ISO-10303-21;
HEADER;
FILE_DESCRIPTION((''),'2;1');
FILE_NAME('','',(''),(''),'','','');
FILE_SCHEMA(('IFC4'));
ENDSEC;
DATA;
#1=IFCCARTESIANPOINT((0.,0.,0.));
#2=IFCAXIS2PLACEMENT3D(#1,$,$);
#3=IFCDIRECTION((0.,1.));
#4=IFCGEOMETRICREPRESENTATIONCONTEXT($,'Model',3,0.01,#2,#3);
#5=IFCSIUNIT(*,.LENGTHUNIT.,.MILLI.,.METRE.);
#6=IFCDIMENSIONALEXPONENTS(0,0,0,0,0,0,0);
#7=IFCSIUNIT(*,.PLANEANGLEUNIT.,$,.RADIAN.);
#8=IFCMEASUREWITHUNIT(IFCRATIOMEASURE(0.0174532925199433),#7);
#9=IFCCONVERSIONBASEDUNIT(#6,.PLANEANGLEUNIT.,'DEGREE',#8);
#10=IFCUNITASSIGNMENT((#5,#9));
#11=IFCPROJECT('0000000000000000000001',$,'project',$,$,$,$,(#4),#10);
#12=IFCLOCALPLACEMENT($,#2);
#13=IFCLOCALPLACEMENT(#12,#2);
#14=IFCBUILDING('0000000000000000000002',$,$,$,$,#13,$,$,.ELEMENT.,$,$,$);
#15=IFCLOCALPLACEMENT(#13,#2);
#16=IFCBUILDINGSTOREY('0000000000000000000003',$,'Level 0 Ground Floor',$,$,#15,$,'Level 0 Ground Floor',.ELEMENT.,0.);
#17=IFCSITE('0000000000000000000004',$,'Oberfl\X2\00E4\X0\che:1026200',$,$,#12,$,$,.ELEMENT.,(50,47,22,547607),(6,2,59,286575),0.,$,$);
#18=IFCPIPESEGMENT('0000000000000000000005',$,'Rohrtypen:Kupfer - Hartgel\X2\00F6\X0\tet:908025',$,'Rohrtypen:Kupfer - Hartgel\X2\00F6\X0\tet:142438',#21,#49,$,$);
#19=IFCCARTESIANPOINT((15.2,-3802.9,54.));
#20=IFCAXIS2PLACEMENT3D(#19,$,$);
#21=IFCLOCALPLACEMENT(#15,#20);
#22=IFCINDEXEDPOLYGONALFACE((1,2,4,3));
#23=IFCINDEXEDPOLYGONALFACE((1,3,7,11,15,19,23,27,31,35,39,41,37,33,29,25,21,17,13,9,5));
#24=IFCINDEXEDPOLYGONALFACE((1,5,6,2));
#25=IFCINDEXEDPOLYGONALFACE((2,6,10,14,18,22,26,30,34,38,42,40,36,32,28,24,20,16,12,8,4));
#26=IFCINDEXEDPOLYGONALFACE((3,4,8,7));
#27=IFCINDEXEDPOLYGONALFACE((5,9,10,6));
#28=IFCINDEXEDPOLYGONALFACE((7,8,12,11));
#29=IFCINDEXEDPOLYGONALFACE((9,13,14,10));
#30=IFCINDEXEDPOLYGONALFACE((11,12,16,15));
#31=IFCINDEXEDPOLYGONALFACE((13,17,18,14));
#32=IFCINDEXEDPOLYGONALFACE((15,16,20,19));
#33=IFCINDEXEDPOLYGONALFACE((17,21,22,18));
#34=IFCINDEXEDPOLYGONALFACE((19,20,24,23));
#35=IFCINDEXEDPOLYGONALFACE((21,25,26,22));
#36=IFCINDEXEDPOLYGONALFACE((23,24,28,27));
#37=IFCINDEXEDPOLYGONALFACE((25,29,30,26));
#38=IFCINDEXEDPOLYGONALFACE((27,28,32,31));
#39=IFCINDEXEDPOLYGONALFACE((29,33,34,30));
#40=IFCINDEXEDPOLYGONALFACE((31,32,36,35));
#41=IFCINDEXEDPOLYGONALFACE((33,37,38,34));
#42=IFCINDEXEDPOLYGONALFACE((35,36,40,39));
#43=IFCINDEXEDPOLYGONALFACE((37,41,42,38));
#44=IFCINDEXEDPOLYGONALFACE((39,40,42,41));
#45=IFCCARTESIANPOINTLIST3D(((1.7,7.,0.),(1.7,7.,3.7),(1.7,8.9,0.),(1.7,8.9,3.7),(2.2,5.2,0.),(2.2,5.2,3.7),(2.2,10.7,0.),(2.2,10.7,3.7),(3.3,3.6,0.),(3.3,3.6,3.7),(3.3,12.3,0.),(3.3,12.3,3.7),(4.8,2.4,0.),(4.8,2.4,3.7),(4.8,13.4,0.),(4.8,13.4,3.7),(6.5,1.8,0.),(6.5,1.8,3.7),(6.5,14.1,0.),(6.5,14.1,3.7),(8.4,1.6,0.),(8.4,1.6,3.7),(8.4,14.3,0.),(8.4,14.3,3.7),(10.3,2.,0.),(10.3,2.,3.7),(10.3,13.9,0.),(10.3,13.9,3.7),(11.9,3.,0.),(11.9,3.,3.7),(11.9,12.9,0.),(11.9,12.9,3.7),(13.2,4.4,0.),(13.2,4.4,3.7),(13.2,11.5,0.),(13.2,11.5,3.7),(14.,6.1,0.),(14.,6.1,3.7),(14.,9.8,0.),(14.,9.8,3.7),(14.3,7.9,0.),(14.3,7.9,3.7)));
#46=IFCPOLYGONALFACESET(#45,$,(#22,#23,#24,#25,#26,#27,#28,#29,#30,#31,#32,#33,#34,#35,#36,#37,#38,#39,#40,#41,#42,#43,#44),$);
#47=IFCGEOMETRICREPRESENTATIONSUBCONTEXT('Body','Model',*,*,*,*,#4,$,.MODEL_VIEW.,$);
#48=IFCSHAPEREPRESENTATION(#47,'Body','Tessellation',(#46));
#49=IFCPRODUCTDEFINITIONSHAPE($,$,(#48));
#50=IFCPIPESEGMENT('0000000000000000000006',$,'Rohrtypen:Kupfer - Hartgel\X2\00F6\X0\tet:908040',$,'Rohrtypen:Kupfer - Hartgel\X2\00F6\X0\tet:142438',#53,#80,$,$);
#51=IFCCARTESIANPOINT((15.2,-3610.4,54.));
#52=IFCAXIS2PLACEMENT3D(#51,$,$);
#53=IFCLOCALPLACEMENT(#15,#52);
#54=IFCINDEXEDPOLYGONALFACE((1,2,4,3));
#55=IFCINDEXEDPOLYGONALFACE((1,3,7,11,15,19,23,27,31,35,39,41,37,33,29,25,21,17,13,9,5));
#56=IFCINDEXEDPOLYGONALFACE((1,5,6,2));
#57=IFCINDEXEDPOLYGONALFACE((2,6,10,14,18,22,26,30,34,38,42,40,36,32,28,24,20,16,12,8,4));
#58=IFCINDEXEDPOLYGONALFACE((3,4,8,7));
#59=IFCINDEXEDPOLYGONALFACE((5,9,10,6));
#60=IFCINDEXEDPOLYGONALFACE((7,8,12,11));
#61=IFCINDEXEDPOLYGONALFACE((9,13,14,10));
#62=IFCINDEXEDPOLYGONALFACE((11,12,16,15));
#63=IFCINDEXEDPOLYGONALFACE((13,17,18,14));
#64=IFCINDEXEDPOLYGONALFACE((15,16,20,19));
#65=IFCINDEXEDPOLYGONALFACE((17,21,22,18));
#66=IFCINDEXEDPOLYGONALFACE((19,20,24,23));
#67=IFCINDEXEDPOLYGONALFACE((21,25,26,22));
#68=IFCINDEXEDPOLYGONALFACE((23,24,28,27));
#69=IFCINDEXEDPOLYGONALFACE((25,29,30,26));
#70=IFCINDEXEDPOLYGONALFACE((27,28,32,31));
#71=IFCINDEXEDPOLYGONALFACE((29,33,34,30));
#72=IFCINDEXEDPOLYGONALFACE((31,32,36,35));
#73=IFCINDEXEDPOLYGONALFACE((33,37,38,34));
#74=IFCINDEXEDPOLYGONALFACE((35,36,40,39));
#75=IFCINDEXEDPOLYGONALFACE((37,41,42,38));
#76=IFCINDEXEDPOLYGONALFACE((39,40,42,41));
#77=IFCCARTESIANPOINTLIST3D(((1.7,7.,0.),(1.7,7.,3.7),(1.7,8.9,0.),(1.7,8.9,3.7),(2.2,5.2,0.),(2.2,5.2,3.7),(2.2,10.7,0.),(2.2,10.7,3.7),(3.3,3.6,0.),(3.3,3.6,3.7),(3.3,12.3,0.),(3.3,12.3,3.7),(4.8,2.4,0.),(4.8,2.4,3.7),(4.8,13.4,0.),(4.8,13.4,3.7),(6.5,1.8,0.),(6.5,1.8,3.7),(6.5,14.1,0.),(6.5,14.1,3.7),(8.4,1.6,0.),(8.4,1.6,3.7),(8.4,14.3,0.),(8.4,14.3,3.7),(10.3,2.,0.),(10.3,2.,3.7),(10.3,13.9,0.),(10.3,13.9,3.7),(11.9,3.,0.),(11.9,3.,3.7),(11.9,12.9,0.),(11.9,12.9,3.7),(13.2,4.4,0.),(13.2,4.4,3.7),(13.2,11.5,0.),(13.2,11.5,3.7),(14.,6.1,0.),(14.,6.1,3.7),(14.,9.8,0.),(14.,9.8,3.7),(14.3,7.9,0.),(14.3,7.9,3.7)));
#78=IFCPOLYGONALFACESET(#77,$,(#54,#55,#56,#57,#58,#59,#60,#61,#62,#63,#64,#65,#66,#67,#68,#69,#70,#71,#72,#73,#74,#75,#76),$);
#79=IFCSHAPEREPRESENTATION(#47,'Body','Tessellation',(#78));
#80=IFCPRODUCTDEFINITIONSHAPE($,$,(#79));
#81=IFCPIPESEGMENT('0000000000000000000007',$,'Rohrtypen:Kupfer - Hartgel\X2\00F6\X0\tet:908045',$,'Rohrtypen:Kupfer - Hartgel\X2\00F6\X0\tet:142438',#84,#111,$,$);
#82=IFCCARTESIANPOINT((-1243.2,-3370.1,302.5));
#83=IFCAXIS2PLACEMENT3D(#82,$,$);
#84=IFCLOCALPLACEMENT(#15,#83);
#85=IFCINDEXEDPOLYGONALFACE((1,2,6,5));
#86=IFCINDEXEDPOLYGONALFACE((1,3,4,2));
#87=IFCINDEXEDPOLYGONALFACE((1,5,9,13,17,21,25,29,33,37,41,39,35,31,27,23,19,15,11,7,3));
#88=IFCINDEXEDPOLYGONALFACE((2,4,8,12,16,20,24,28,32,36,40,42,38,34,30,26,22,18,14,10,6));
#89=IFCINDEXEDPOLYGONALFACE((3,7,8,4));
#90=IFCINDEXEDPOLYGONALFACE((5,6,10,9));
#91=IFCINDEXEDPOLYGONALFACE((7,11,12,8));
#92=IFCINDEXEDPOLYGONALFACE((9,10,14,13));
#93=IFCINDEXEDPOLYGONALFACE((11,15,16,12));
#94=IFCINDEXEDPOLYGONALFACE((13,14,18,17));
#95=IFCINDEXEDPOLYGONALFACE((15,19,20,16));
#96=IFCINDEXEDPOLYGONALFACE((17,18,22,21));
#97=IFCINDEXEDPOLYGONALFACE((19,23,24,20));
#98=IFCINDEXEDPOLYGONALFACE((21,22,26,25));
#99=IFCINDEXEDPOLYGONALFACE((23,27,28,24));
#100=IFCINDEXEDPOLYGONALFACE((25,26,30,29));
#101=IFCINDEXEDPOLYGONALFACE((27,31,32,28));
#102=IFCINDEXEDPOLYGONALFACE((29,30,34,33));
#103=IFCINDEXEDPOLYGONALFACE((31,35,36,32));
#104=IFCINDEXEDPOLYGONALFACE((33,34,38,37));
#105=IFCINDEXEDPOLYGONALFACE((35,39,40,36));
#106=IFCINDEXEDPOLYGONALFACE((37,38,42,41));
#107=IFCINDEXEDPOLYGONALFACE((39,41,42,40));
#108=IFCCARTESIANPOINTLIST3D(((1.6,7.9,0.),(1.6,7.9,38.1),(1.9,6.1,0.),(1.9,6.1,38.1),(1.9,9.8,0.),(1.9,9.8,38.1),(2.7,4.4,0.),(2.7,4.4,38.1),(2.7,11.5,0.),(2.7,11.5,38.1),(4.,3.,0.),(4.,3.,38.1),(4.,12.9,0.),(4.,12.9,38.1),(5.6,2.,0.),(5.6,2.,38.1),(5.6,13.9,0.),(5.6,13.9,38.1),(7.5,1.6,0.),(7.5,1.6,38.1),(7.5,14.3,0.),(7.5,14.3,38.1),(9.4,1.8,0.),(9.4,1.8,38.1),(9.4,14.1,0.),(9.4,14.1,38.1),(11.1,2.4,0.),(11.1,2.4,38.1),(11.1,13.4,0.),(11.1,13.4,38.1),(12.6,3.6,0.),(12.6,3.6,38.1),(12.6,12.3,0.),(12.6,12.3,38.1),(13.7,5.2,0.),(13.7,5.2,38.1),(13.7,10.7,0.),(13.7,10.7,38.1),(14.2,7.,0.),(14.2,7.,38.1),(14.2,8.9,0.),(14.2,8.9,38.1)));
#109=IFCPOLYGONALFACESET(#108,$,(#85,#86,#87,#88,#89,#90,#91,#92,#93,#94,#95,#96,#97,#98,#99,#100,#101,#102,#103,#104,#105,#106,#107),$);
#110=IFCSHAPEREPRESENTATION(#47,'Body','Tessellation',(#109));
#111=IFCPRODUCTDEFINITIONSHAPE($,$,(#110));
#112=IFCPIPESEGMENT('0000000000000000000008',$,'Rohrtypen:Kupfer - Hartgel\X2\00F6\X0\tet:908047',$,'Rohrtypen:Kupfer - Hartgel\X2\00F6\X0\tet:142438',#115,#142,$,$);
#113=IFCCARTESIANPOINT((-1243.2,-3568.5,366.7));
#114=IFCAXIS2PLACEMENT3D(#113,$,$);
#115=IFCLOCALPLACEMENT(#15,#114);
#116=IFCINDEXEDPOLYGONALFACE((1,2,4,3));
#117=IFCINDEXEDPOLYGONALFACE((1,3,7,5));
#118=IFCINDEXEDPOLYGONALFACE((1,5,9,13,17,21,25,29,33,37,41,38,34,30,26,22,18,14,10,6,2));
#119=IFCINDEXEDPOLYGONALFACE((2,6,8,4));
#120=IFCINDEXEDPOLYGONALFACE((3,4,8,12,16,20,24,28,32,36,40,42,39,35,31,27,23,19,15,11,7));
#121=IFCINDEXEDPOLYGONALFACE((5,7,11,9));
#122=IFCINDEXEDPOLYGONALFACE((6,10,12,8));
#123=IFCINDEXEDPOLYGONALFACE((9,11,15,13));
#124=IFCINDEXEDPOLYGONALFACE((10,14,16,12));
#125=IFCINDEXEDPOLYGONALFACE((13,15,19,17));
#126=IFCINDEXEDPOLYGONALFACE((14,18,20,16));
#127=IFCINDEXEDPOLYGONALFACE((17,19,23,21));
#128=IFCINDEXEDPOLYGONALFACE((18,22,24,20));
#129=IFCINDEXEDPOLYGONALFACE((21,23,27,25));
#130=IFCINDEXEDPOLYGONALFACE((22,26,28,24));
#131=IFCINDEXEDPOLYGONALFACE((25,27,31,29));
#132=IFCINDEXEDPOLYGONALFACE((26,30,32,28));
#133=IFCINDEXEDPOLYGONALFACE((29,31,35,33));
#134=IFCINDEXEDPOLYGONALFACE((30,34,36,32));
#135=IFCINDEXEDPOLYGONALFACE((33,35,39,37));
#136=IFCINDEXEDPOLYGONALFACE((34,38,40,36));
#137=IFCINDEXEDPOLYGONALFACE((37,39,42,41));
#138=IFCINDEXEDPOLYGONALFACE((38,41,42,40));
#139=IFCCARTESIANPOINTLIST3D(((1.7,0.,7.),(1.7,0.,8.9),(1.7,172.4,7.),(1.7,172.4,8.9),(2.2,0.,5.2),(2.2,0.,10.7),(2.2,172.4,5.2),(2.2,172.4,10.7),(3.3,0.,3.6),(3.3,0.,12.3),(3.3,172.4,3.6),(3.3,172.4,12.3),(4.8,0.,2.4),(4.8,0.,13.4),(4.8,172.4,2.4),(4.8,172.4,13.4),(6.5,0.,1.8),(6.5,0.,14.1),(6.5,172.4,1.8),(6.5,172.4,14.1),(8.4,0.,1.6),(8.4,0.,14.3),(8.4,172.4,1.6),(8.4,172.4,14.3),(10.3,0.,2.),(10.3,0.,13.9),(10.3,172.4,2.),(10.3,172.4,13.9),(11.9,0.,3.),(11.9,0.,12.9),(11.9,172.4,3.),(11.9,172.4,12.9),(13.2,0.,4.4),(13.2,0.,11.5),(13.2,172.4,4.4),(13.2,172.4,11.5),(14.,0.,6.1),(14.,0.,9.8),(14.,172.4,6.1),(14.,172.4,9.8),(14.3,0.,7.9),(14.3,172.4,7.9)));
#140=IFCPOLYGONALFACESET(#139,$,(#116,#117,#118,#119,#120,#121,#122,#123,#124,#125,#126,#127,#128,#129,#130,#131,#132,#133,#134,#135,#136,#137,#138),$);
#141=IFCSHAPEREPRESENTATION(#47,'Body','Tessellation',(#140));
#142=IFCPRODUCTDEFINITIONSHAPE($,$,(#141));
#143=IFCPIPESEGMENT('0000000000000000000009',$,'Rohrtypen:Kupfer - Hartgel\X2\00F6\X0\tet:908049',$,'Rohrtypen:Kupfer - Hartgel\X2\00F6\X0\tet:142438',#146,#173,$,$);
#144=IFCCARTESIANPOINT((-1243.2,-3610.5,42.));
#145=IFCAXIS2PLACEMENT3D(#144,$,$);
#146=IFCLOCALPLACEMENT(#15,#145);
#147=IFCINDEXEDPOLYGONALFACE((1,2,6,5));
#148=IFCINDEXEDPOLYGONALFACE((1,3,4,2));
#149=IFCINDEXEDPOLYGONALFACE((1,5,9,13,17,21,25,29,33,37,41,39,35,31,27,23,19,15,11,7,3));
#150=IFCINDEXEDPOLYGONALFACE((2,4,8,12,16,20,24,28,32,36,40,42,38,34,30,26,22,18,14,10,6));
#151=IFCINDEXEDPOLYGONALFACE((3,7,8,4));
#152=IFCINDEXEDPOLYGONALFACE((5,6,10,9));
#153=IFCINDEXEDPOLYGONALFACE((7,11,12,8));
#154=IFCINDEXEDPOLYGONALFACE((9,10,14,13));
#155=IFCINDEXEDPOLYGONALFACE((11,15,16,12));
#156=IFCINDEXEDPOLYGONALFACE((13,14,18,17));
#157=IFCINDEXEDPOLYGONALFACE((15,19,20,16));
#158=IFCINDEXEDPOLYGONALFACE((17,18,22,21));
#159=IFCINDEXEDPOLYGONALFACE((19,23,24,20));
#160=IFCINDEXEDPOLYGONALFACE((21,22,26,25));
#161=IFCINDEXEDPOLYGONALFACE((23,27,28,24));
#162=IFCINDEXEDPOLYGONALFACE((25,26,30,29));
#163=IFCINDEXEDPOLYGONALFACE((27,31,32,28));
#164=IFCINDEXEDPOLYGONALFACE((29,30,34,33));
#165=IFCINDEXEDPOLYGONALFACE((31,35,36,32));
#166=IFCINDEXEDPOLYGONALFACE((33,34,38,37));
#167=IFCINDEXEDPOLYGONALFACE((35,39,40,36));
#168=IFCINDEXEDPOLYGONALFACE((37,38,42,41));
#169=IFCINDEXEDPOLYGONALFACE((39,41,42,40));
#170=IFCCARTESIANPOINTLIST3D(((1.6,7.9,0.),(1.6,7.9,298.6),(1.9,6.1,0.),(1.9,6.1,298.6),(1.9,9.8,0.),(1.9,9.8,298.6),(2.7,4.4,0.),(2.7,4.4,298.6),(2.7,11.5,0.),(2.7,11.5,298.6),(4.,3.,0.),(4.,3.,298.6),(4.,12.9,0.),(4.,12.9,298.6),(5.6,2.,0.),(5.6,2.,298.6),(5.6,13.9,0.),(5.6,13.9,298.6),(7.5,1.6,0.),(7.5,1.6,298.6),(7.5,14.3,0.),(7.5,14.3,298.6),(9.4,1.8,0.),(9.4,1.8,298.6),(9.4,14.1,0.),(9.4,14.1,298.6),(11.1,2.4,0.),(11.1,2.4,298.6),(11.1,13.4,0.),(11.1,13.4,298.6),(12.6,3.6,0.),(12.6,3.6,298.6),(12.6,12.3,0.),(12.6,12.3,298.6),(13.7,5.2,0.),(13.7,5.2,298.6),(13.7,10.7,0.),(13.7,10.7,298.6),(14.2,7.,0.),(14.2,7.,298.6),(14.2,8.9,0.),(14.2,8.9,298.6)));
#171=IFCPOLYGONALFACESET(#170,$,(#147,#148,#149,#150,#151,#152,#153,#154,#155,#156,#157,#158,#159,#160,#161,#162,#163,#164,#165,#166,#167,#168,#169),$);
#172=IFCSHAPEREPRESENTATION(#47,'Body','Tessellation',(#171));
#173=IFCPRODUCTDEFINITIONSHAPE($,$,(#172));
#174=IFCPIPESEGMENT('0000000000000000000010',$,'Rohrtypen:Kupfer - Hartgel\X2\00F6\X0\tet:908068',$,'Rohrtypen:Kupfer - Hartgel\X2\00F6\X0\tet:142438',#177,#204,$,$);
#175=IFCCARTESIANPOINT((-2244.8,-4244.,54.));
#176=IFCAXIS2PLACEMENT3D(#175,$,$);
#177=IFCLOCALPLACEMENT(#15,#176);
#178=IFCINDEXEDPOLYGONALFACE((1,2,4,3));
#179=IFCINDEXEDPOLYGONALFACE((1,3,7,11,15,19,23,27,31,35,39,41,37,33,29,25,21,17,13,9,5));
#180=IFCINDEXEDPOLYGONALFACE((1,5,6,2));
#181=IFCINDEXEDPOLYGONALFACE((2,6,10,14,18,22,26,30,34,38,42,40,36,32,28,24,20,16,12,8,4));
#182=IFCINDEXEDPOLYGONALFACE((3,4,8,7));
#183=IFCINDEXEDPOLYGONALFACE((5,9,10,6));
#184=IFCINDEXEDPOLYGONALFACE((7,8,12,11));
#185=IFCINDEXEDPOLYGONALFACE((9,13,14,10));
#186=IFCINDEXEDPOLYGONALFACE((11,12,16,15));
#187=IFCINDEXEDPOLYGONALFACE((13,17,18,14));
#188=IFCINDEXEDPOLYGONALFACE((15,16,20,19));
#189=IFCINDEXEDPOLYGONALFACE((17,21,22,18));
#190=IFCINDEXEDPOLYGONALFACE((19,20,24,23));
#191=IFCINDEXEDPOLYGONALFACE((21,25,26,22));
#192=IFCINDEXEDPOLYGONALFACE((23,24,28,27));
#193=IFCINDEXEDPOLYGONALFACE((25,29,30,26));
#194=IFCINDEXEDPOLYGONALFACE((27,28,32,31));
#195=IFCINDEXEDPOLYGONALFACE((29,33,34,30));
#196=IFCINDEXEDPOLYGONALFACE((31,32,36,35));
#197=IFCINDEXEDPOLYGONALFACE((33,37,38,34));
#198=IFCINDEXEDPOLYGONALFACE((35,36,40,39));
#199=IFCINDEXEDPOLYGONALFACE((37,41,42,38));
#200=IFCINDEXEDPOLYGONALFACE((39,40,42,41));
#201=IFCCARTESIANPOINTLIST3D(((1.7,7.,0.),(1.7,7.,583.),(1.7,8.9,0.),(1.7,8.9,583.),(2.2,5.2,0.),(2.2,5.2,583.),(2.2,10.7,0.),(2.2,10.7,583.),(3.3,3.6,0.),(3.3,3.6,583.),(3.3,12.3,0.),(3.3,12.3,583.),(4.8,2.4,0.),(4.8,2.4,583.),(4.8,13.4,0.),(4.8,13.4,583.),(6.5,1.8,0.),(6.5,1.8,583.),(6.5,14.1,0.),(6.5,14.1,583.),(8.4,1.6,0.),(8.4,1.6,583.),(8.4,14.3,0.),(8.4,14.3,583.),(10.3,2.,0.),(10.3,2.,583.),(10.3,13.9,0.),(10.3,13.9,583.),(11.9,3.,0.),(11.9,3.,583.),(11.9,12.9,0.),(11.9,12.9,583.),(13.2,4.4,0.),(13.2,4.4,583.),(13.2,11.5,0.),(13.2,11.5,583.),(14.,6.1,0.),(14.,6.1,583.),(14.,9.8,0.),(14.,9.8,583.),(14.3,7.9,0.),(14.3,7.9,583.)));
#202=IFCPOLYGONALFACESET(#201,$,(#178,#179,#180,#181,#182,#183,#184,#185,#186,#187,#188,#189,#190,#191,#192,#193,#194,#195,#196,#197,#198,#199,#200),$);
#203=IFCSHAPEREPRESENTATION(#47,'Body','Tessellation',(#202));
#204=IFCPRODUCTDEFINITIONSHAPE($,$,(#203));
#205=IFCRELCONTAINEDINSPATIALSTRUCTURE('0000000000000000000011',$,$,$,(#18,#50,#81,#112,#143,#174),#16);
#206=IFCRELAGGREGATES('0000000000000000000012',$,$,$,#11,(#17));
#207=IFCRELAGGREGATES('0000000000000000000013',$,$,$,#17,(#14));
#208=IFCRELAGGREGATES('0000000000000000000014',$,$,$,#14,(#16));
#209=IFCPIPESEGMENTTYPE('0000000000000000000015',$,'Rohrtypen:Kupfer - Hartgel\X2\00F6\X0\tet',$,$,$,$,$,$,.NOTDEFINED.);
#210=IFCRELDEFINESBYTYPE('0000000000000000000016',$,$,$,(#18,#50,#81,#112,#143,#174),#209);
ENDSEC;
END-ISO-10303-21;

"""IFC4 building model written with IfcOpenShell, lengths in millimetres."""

from ifc_helpers import new_model, entity, si_unit, converted_unit, direction, frame, frame_2d, origin, origin_2d_with_axis, place, context, subcontext, project, spatial, circle, extrude, type_object, element, save


model = new_model("IFC4")

# Units and contexts
model_context = context("Model", 3, precision=0.01, world=origin(), true_north=direction((0.0, 1.0)))
body_context = subcontext(model_context, "Body", "Model", "MODEL_VIEW")
ifc_project = project(units=[si_unit("LENGTHUNIT", "METRE", prefix="MILLI"), converted_unit("PLANEANGLEUNIT", "DEGREE", entity("IfcRatioMeasure", 0.0174532925199433), si_unit("PLANEANGLEUNIT", "RADIAN"), dimensions=[0, 0, 0, 0, 0, 0, 0])], contexts=[model_context])

# Site, building, storey
site_placement = place(None, origin())
site = spatial("IfcSite", under=ifc_project, at=site_placement, Name="Oberfläche:1026200", CompositionType="ELEMENT", RefLatitude=(50, 47, 22, 547607), RefLongitude=(6, 2, 59, 286575), RefElevation=0.0)
building_placement = place(site_placement, origin())
building = spatial("IfcBuilding", under=site, at=building_placement, CompositionType="ELEMENT")
storey_placement = place(building_placement, origin())
storey = spatial("IfcBuildingStorey", under=building, at=storey_placement, Name="Level 0 Ground Floor", LongName="Level 0 Ground Floor", CompositionType="ELEMENT", Elevation=0.0)

# Pipe segments
pipe_segment_type = type_object("IfcPipeSegmentType", Name="Rohrtypen:Kupfer - Hartgelötet", PredefinedType="NOTDEFINED")
pipe_segment_1_placement = place(storey_placement, frame((15.2, -3802.9, 54.0)))
element("IfcPipeSegment", 1, at=pipe_segment_1_placement, inside=storey, type_object=pipe_segment_type, Name="Rohrtypen:Kupfer - Hartgelötet:908025", ObjectType="Rohrtypen:Kupfer - Hartgelötet:142438", context=body_context, shape_type="SweptSolid", body=[
    extrude(circle(Radius=6.3, at=frame_2d((0.0, 0.0), x_axis=(1.0, 0.0))), frame((7.9, 7.9, 0.0)), (0.0, 0.0, 1.0), 3.7),
])
pipe_segment_2_placement = place(storey_placement, frame((15.2, -3610.4, 54.0)))
element("IfcPipeSegment", 2, at=pipe_segment_2_placement, inside=storey, type_object=pipe_segment_type, Name="Rohrtypen:Kupfer - Hartgelötet:908040", ObjectType="Rohrtypen:Kupfer - Hartgelötet:142438", context=body_context, shape_type="SweptSolid", body=[
    extrude(circle(Radius=6.3, at=frame_2d((0.0, 0.0), x_axis=(1.0, 0.0))), frame((7.9, 7.9, 0.0)), (0.0, 0.0, 1.0), 3.7),
])
pipe_segment_3_placement = place(storey_placement, frame((-1243.2, -3370.1, 302.5)))
element("IfcPipeSegment", 3, at=pipe_segment_3_placement, inside=storey, type_object=pipe_segment_type, Name="Rohrtypen:Kupfer - Hartgelötet:908045", ObjectType="Rohrtypen:Kupfer - Hartgelötet:142438", context=body_context, shape_type="SweptSolid", body=[
    extrude(circle(Radius=6.3, at=origin_2d_with_axis()), frame((7.9, 7.9, 0.0), z_axis=(0.0, 0.0, 1.0), x_axis=(-1.0, 0.0, 0.0)), (0.0, 0.0, 1.0), 38.1),
])
pipe_segment_4_placement = place(storey_placement, frame((-1243.2, -3568.5, 366.7)))
element("IfcPipeSegment", 4, at=pipe_segment_4_placement, inside=storey, type_object=pipe_segment_type, Name="Rohrtypen:Kupfer - Hartgelötet:908047", ObjectType="Rohrtypen:Kupfer - Hartgelötet:142438", context=body_context, shape_type="SweptSolid", body=[
    extrude(circle(Radius=6.3, at=frame_2d((0.0, 0.0), x_axis=(1.0, 0.0))), frame((7.9, 0.0, 7.9), z_axis=(0.0, 1.0, 0.0), x_axis=(1.0, 0.0, 0.0)), (0.0, 0.0, 1.0), 172.4),
])
pipe_segment_5_placement = place(storey_placement, frame((-1243.2, -3610.5, 42.0)))
element("IfcPipeSegment", 5, at=pipe_segment_5_placement, inside=storey, type_object=pipe_segment_type, Name="Rohrtypen:Kupfer - Hartgelötet:908049", ObjectType="Rohrtypen:Kupfer - Hartgelötet:142438", context=body_context, shape_type="SweptSolid", body=[
    extrude(circle(Radius=6.3, at=frame_2d((0.0, 0.0), x_axis=(1.0, 0.0))), frame((7.9, 7.9, 0.0), z_axis=(0.0, 0.0, 1.0), x_axis=(-1.0, 0.0, 0.0)), (0.0, 0.0, 1.0), 298.6),
])
pipe_segment_6_placement = place(storey_placement, frame((-2244.8, -4244.0, 54.0)))
element("IfcPipeSegment", 6, at=pipe_segment_6_placement, inside=storey, type_object=pipe_segment_type, Name="Rohrtypen:Kupfer - Hartgelötet:908068", ObjectType="Rohrtypen:Kupfer - Hartgelötet:142438", context=body_context, shape_type="SweptSolid", body=[
    extrude(circle(Radius=6.3, at=frame_2d((0.0, 0.0), x_axis=(1.0, 0.0))), frame((7.9, 7.9, 0.0)), (0.0, 0.0, 1.0), 583.0),
])

save(model, "model.ifc")
